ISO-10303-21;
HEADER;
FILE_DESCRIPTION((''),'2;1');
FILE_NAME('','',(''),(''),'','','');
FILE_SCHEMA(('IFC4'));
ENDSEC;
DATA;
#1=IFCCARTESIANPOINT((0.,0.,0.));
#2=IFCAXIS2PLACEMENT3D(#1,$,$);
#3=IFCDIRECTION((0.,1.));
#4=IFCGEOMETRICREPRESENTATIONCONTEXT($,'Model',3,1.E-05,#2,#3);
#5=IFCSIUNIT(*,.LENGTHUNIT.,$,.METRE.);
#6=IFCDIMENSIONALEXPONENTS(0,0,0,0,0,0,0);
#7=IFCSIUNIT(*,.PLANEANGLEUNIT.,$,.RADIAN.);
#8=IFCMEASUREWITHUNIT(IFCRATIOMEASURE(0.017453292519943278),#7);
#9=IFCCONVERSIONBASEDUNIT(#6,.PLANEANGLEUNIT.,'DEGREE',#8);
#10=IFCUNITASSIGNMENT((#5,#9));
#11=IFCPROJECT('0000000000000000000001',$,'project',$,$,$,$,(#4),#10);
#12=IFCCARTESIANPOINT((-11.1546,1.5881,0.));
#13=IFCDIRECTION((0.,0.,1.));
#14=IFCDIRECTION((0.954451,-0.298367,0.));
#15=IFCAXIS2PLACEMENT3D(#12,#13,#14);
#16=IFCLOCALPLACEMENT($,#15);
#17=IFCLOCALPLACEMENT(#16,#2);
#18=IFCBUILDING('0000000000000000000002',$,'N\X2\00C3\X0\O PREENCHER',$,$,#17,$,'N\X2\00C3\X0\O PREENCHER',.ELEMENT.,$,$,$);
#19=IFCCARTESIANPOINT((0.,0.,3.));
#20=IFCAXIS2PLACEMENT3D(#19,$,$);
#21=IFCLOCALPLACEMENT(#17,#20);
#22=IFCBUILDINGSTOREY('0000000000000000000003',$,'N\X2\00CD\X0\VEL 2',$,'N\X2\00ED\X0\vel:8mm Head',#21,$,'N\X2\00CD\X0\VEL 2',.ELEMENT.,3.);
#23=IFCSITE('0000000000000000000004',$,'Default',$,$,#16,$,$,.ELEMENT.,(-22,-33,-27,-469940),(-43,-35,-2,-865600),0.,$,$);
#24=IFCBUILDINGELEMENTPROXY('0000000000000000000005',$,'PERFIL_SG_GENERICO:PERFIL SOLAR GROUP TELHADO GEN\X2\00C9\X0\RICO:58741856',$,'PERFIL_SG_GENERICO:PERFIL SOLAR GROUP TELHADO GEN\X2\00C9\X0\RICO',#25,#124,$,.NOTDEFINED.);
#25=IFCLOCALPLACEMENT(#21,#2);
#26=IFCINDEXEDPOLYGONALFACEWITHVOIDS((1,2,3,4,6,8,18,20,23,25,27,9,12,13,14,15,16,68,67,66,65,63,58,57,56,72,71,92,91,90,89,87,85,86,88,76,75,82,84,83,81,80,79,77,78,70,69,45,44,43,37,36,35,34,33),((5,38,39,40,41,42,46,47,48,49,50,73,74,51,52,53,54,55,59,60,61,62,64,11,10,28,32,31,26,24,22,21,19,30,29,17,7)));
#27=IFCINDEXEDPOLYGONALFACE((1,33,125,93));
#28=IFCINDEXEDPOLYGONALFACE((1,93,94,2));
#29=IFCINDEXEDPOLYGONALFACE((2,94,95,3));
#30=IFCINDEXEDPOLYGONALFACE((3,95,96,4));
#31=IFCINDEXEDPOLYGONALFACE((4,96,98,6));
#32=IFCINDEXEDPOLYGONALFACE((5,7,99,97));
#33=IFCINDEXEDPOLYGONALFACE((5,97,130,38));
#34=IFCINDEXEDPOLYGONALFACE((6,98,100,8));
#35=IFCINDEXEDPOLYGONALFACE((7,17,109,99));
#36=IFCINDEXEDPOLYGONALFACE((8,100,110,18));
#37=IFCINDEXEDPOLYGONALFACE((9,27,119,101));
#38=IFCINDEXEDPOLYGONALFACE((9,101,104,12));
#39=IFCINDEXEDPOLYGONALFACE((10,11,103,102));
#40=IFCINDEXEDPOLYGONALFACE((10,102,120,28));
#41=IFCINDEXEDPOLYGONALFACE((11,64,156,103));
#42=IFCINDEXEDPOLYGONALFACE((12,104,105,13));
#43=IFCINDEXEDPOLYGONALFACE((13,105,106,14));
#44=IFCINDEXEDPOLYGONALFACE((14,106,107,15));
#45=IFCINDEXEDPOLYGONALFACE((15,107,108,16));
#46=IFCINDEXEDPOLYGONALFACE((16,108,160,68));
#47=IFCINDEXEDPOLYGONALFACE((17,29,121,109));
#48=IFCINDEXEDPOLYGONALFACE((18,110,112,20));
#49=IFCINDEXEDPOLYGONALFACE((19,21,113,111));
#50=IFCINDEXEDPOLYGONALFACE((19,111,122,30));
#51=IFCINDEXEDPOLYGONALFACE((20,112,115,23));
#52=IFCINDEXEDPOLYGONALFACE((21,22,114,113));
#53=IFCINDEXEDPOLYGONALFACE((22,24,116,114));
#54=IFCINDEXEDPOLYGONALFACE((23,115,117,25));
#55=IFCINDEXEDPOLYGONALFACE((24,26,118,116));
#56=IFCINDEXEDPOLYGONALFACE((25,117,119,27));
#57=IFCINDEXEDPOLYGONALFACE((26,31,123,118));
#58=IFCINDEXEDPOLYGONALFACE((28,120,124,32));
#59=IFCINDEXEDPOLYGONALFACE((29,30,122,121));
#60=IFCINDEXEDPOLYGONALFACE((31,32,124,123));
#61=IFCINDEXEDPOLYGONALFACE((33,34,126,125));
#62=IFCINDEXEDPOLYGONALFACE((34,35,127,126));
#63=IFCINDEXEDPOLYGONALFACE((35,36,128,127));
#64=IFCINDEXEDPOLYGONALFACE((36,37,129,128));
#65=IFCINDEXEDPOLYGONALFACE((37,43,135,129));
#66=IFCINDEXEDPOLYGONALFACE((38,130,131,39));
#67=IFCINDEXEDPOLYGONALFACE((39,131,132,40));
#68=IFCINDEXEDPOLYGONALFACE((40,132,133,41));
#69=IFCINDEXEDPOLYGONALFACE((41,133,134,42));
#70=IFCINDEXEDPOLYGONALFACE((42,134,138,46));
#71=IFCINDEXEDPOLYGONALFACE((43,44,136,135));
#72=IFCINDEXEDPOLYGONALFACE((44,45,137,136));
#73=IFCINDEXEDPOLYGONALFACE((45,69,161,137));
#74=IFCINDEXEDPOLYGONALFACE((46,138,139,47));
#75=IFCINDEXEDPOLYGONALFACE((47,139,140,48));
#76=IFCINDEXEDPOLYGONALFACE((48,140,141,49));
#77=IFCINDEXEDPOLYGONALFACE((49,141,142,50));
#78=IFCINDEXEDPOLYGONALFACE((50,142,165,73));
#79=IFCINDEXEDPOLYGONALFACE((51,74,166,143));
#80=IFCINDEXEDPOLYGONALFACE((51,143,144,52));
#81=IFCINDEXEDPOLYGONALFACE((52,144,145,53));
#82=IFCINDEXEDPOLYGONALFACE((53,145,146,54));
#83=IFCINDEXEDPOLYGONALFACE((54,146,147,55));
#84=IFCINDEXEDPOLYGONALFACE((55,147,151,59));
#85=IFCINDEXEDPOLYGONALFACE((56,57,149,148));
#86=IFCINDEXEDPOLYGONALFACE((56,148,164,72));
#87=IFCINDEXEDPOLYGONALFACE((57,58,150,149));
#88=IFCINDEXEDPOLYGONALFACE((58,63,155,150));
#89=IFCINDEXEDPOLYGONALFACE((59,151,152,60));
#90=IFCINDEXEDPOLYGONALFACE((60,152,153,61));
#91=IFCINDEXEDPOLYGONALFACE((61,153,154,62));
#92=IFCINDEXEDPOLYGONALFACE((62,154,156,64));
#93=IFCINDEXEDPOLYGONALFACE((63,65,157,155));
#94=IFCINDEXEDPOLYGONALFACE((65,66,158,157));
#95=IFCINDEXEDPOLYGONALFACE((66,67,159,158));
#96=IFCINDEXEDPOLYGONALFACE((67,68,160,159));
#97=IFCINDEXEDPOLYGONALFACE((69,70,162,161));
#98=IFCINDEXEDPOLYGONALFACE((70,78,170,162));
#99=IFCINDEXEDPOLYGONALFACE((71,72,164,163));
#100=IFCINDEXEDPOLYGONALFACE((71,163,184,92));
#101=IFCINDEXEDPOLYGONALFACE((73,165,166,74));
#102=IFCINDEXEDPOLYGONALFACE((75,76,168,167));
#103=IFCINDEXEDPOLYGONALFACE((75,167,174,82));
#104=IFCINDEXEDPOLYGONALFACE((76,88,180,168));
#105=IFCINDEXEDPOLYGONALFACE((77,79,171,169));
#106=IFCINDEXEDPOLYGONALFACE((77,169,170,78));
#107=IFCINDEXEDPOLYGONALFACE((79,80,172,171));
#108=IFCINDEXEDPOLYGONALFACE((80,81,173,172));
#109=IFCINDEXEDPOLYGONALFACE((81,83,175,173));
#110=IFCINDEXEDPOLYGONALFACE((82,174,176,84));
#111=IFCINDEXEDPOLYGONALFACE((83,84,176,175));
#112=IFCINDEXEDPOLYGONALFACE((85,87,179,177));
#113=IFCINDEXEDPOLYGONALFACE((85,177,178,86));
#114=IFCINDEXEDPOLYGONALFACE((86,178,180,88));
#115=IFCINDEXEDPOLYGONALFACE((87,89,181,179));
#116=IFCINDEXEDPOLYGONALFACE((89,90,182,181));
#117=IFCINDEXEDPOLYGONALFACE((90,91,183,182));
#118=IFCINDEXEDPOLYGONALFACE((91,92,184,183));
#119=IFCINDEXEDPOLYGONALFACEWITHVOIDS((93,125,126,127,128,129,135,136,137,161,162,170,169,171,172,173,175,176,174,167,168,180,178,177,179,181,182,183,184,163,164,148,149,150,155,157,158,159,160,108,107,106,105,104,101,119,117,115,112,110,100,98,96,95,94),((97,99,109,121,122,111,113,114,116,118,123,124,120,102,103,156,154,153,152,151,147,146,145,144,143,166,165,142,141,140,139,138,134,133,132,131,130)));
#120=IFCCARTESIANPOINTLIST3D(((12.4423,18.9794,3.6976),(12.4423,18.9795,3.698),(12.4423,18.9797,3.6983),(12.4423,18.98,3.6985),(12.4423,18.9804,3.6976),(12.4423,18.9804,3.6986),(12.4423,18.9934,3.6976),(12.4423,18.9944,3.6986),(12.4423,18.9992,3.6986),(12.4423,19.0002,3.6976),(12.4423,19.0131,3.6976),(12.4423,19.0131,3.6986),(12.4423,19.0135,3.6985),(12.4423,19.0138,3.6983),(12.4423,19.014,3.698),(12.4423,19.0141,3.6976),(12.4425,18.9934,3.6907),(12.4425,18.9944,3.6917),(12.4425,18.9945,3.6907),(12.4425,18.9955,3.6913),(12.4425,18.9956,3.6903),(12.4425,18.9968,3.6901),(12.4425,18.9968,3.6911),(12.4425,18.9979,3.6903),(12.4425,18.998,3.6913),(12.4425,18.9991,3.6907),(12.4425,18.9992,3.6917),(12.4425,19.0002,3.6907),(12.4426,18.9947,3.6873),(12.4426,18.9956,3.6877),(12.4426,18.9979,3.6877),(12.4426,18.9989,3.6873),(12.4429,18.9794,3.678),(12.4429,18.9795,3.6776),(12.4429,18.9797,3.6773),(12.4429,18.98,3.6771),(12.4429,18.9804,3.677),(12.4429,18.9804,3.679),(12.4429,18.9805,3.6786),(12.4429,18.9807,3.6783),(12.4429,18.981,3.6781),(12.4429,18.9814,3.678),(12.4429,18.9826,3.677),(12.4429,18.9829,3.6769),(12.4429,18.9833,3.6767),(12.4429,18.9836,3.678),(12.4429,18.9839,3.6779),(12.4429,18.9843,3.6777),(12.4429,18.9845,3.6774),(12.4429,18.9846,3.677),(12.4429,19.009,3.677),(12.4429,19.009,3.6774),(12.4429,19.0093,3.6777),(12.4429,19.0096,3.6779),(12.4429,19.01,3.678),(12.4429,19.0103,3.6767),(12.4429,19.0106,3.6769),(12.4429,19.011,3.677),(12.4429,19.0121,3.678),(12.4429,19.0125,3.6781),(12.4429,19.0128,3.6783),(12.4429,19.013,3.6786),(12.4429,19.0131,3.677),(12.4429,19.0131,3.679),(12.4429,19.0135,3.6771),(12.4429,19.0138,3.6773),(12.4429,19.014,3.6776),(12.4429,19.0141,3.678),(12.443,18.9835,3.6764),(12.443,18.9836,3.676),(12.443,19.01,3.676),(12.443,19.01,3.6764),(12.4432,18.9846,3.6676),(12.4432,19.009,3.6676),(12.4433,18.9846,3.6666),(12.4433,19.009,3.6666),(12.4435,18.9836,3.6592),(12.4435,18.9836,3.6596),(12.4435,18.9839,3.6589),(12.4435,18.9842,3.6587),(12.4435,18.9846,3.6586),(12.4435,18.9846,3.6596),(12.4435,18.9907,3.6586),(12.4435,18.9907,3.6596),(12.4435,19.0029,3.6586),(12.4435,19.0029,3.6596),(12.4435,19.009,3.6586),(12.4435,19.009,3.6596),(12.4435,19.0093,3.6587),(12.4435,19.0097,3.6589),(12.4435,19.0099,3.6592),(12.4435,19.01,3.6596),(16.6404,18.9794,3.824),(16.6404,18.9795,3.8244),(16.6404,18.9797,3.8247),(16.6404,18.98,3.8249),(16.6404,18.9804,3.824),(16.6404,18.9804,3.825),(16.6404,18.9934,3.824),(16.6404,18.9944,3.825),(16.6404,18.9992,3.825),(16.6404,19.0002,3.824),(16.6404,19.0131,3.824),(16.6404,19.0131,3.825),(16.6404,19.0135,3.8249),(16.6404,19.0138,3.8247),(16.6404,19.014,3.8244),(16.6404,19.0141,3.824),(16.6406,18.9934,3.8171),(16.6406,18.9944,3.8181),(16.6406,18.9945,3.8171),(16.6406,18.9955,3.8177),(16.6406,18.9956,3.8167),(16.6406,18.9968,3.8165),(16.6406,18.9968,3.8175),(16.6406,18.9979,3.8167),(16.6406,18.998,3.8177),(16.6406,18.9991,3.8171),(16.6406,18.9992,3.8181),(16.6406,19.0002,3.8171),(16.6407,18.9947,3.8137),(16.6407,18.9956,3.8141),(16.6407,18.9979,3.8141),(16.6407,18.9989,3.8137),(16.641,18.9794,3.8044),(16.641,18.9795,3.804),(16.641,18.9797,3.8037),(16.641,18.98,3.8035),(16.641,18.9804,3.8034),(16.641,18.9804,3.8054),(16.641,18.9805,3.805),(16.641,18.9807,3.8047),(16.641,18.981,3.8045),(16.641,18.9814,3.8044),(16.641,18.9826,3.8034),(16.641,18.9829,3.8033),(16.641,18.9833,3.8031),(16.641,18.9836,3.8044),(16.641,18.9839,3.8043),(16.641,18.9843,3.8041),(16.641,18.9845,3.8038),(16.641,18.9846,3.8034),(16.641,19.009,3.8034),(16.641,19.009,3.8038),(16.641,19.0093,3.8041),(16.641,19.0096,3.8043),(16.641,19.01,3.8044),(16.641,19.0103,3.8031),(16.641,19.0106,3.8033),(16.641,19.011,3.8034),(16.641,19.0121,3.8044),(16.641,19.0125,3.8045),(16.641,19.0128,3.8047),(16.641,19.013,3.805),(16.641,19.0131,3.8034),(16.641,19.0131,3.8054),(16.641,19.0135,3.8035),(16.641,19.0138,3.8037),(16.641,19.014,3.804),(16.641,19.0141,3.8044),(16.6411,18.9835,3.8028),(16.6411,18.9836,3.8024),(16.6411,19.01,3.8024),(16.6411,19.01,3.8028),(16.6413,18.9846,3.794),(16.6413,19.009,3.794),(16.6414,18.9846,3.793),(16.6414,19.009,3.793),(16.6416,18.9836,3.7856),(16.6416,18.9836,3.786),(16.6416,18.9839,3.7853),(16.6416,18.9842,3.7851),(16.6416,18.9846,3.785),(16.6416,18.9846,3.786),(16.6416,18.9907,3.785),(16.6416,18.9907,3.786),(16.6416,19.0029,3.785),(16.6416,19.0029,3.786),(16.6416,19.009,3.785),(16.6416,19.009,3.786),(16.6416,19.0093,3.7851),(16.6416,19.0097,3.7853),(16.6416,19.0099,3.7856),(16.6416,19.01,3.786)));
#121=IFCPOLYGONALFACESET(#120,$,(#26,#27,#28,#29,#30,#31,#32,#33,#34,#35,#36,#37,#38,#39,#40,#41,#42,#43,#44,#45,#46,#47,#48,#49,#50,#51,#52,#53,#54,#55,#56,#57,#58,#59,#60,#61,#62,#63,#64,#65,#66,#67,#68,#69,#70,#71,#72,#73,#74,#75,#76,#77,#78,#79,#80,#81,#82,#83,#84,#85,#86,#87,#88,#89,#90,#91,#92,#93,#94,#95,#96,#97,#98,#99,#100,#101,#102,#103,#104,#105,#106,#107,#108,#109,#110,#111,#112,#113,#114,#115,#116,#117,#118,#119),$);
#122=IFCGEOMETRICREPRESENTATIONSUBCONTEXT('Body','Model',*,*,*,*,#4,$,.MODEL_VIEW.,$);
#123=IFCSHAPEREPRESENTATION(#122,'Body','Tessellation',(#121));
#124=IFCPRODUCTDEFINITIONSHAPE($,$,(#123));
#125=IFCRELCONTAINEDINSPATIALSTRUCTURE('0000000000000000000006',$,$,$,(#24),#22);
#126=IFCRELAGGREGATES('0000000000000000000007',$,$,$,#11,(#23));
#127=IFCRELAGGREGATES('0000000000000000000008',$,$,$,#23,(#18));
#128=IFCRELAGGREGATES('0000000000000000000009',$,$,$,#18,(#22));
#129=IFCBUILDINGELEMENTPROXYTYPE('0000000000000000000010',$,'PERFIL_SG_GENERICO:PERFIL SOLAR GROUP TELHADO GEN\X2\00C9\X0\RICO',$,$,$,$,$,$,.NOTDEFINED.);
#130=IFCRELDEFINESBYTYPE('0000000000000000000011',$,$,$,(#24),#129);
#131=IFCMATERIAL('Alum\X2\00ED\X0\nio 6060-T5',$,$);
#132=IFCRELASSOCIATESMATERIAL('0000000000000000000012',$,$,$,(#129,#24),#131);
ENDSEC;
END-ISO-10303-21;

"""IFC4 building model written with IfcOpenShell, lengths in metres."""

from ifc_helpers import new_model, entity, si_unit, converted_unit, direction, frame, origin, place, context, subcontext, project, spatial, line, arc, indexed_curve, outline, extrude, source, transform, mapped, material, type_object, type_shapes, element, save


model = new_model("IFC4")

# Units and contexts
model_context = context("Model", 3, precision=1e-05, world=origin(), true_north=direction((0.0, 1.0)))
body_context = subcontext(model_context, "Body", "Model", "MODEL_VIEW")
ifc_project = project(units=[si_unit("LENGTHUNIT", "METRE"), converted_unit("PLANEANGLEUNIT", "DEGREE", entity("IfcRatioMeasure", 0.017453292519943278), si_unit("PLANEANGLEUNIT", "RADIAN"), dimensions=[0, 0, 0, 0, 0, 0, 0])], contexts=[model_context])

# Site, building, storey
site_placement = place(None, frame((-11.1546, 1.5881, 0.0), z_axis=(0.0, 0.0, 1.0), x_axis=(0.954451, -0.298367, 0.0)))
site = spatial("IfcSite", under=ifc_project, at=site_placement, Name="Default", CompositionType="ELEMENT", RefLatitude=(-22, -33, -27, -469940), RefLongitude=(-43, -35, -2, -865600), RefElevation=0.0)
building_placement = place(site_placement, origin())
building = spatial("IfcBuilding", under=site, at=building_placement, Name="NÃO PREENCHER", LongName="NÃO PREENCHER", CompositionType="ELEMENT")
storey_placement = place(building_placement, frame((0.0, 0.0, 3.0)))
storey = spatial("IfcBuildingStorey", under=building, at=storey_placement, Name="NÍVEL 2", ObjectType="Nível:8mm Head", LongName="NÍVEL 2", CompositionType="ELEMENT", Elevation=3.0)

# Building element proxy
ifc_material_1 = material(Name="Alumínio 6060-T5")
building_element_proxy_type_1 = type_object("IfcBuildingElementProxyType", Name="PERFIL_SG_GENERICO:PERFIL SOLAR GROUP TELHADO GENÉRICO", PredefinedType="NOTDEFINED", material=ifc_material_1)
shared_shape_1 = source(origin(), body_context, "Body", "SweptSolid", [
    extrude(outline(indexed_curve([(-0.0122, -0.0169), (-0.0061, -0.0169), (-0.0061, -0.0159), (-0.0122, -0.0159), (-0.0122, -0.0089), (0.0122, -0.0089), (0.0122, -0.0159), (0.0061, -0.0159), (0.0061, -0.0169), (0.0122, -0.0169), (0.0129, -0.0166), (0.0132, -0.0159), (0.0132, 0.0005), (0.0135, 0.0012), (0.0142, 0.0015), (0.0164, 0.0015), (0.0171, 0.0018), (0.0174, 0.0025), (0.0174, 0.0221), (0.0171, 0.0228), (0.0164, 0.0231), (0.0024, 0.0231), (0.0024, 0.0162), (0.0, 0.0156), (-0.0024, 0.0162), (-0.0024, 0.0231), (-0.0164, 0.0231), (-0.0171, 0.0228), (-0.0174, 0.0221), (-0.0174, 0.0025), (-0.0171, 0.0018), (-0.0164, 0.0015), (-0.0142, 0.0015), (-0.0135, 0.0012), (-0.0132, 0.0005), (-0.0132, -0.0159), (-0.0129, -0.0166)], segments=[line(1, 2, 3, 4, 5, 6, 7, 8, 9, 10), arc(10, 11, 12), line(12, 13), arc(13, 14, 15), line(15, 16), arc(16, 17, 18), line(18, 19), arc(19, 20, 21), line(21, 22, 23), arc(23, 24, 25), line(25, 26, 27), arc(27, 28, 29), line(29, 30), arc(30, 31, 32), line(32, 33), arc(33, 34, 35), line(35, 36), arc(36, 37, 1)], self_intersect=False), holes=[indexed_curve([(-0.0122, -0.0079), (-0.0122, 0.0015), (-0.0125, 0.0022), (-0.0132, 0.0025), (-0.0154, 0.0025), (-0.0161, 0.0028), (-0.0164, 0.0035), (-0.0164, 0.0221), (-0.0034, 0.0221), (-0.0034, 0.0152), (-0.0021, 0.0118), (-0.0012, 0.0122), (-0.0023, 0.0151), (0.0, 0.0146), (0.0023, 0.0151), (0.0012, 0.0122), (0.0021, 0.0118), (0.0034, 0.0152), (0.0034, 0.0221), (0.0164, 0.0221), (0.0164, 0.0035), (0.0161, 0.0028), (0.0154, 0.0025), (0.0132, 0.0025), (0.0125, 0.0022), (0.0122, 0.0015), (0.0122, -0.0079)], segments=[line(1, 2), arc(2, 3, 4), line(4, 5), arc(5, 6, 7), line(7, 8, 9, 10, 11, 12, 13), arc(13, 14, 15), line(15, 16, 17, 18, 19, 20, 21), arc(21, 22, 23), line(23, 24), arc(24, 25, 26), line(26, 27, 1)], self_intersect=False)]), frame((0.0, 0.0, 0.0169), z_axis=(1.0, 0.0, 0.0), x_axis=(0.0, 1.0, 0.0)), (0.0, 0.0, 1.0), 4.2),
])
type_shapes(building_element_proxy_type_1, [shared_shape_1])
for number, where, z_axis, x_axis, name in (
    (1, (12.4435, 18.9968, 3.6586), (-0.030095, 0.0, 0.999547), (0.999547, 0.0, 0.030095), "PERFIL_SG_GENERICO:PERFIL SOLAR GROUP TELHADO GENÉRICO:58741856"),
):
    element("IfcBuildingElementProxy", number, at=place(storey_placement, frame(where, z_axis=z_axis, x_axis=x_axis)), inside=storey, type_object=building_element_proxy_type_1, material=ifc_material_1, Name=name, ObjectType="PERFIL_SG_GENERICO:PERFIL SOLAR GROUP TELHADO GENÉRICO", PredefinedType="NOTDEFINED", context=body_context, shape_type="MappedRepresentation", body=[
        mapped(shared_shape_1, transform((0.0, 0.0, 0.0), scale=1.0)),
    ])

save(model, "model.ifc")
